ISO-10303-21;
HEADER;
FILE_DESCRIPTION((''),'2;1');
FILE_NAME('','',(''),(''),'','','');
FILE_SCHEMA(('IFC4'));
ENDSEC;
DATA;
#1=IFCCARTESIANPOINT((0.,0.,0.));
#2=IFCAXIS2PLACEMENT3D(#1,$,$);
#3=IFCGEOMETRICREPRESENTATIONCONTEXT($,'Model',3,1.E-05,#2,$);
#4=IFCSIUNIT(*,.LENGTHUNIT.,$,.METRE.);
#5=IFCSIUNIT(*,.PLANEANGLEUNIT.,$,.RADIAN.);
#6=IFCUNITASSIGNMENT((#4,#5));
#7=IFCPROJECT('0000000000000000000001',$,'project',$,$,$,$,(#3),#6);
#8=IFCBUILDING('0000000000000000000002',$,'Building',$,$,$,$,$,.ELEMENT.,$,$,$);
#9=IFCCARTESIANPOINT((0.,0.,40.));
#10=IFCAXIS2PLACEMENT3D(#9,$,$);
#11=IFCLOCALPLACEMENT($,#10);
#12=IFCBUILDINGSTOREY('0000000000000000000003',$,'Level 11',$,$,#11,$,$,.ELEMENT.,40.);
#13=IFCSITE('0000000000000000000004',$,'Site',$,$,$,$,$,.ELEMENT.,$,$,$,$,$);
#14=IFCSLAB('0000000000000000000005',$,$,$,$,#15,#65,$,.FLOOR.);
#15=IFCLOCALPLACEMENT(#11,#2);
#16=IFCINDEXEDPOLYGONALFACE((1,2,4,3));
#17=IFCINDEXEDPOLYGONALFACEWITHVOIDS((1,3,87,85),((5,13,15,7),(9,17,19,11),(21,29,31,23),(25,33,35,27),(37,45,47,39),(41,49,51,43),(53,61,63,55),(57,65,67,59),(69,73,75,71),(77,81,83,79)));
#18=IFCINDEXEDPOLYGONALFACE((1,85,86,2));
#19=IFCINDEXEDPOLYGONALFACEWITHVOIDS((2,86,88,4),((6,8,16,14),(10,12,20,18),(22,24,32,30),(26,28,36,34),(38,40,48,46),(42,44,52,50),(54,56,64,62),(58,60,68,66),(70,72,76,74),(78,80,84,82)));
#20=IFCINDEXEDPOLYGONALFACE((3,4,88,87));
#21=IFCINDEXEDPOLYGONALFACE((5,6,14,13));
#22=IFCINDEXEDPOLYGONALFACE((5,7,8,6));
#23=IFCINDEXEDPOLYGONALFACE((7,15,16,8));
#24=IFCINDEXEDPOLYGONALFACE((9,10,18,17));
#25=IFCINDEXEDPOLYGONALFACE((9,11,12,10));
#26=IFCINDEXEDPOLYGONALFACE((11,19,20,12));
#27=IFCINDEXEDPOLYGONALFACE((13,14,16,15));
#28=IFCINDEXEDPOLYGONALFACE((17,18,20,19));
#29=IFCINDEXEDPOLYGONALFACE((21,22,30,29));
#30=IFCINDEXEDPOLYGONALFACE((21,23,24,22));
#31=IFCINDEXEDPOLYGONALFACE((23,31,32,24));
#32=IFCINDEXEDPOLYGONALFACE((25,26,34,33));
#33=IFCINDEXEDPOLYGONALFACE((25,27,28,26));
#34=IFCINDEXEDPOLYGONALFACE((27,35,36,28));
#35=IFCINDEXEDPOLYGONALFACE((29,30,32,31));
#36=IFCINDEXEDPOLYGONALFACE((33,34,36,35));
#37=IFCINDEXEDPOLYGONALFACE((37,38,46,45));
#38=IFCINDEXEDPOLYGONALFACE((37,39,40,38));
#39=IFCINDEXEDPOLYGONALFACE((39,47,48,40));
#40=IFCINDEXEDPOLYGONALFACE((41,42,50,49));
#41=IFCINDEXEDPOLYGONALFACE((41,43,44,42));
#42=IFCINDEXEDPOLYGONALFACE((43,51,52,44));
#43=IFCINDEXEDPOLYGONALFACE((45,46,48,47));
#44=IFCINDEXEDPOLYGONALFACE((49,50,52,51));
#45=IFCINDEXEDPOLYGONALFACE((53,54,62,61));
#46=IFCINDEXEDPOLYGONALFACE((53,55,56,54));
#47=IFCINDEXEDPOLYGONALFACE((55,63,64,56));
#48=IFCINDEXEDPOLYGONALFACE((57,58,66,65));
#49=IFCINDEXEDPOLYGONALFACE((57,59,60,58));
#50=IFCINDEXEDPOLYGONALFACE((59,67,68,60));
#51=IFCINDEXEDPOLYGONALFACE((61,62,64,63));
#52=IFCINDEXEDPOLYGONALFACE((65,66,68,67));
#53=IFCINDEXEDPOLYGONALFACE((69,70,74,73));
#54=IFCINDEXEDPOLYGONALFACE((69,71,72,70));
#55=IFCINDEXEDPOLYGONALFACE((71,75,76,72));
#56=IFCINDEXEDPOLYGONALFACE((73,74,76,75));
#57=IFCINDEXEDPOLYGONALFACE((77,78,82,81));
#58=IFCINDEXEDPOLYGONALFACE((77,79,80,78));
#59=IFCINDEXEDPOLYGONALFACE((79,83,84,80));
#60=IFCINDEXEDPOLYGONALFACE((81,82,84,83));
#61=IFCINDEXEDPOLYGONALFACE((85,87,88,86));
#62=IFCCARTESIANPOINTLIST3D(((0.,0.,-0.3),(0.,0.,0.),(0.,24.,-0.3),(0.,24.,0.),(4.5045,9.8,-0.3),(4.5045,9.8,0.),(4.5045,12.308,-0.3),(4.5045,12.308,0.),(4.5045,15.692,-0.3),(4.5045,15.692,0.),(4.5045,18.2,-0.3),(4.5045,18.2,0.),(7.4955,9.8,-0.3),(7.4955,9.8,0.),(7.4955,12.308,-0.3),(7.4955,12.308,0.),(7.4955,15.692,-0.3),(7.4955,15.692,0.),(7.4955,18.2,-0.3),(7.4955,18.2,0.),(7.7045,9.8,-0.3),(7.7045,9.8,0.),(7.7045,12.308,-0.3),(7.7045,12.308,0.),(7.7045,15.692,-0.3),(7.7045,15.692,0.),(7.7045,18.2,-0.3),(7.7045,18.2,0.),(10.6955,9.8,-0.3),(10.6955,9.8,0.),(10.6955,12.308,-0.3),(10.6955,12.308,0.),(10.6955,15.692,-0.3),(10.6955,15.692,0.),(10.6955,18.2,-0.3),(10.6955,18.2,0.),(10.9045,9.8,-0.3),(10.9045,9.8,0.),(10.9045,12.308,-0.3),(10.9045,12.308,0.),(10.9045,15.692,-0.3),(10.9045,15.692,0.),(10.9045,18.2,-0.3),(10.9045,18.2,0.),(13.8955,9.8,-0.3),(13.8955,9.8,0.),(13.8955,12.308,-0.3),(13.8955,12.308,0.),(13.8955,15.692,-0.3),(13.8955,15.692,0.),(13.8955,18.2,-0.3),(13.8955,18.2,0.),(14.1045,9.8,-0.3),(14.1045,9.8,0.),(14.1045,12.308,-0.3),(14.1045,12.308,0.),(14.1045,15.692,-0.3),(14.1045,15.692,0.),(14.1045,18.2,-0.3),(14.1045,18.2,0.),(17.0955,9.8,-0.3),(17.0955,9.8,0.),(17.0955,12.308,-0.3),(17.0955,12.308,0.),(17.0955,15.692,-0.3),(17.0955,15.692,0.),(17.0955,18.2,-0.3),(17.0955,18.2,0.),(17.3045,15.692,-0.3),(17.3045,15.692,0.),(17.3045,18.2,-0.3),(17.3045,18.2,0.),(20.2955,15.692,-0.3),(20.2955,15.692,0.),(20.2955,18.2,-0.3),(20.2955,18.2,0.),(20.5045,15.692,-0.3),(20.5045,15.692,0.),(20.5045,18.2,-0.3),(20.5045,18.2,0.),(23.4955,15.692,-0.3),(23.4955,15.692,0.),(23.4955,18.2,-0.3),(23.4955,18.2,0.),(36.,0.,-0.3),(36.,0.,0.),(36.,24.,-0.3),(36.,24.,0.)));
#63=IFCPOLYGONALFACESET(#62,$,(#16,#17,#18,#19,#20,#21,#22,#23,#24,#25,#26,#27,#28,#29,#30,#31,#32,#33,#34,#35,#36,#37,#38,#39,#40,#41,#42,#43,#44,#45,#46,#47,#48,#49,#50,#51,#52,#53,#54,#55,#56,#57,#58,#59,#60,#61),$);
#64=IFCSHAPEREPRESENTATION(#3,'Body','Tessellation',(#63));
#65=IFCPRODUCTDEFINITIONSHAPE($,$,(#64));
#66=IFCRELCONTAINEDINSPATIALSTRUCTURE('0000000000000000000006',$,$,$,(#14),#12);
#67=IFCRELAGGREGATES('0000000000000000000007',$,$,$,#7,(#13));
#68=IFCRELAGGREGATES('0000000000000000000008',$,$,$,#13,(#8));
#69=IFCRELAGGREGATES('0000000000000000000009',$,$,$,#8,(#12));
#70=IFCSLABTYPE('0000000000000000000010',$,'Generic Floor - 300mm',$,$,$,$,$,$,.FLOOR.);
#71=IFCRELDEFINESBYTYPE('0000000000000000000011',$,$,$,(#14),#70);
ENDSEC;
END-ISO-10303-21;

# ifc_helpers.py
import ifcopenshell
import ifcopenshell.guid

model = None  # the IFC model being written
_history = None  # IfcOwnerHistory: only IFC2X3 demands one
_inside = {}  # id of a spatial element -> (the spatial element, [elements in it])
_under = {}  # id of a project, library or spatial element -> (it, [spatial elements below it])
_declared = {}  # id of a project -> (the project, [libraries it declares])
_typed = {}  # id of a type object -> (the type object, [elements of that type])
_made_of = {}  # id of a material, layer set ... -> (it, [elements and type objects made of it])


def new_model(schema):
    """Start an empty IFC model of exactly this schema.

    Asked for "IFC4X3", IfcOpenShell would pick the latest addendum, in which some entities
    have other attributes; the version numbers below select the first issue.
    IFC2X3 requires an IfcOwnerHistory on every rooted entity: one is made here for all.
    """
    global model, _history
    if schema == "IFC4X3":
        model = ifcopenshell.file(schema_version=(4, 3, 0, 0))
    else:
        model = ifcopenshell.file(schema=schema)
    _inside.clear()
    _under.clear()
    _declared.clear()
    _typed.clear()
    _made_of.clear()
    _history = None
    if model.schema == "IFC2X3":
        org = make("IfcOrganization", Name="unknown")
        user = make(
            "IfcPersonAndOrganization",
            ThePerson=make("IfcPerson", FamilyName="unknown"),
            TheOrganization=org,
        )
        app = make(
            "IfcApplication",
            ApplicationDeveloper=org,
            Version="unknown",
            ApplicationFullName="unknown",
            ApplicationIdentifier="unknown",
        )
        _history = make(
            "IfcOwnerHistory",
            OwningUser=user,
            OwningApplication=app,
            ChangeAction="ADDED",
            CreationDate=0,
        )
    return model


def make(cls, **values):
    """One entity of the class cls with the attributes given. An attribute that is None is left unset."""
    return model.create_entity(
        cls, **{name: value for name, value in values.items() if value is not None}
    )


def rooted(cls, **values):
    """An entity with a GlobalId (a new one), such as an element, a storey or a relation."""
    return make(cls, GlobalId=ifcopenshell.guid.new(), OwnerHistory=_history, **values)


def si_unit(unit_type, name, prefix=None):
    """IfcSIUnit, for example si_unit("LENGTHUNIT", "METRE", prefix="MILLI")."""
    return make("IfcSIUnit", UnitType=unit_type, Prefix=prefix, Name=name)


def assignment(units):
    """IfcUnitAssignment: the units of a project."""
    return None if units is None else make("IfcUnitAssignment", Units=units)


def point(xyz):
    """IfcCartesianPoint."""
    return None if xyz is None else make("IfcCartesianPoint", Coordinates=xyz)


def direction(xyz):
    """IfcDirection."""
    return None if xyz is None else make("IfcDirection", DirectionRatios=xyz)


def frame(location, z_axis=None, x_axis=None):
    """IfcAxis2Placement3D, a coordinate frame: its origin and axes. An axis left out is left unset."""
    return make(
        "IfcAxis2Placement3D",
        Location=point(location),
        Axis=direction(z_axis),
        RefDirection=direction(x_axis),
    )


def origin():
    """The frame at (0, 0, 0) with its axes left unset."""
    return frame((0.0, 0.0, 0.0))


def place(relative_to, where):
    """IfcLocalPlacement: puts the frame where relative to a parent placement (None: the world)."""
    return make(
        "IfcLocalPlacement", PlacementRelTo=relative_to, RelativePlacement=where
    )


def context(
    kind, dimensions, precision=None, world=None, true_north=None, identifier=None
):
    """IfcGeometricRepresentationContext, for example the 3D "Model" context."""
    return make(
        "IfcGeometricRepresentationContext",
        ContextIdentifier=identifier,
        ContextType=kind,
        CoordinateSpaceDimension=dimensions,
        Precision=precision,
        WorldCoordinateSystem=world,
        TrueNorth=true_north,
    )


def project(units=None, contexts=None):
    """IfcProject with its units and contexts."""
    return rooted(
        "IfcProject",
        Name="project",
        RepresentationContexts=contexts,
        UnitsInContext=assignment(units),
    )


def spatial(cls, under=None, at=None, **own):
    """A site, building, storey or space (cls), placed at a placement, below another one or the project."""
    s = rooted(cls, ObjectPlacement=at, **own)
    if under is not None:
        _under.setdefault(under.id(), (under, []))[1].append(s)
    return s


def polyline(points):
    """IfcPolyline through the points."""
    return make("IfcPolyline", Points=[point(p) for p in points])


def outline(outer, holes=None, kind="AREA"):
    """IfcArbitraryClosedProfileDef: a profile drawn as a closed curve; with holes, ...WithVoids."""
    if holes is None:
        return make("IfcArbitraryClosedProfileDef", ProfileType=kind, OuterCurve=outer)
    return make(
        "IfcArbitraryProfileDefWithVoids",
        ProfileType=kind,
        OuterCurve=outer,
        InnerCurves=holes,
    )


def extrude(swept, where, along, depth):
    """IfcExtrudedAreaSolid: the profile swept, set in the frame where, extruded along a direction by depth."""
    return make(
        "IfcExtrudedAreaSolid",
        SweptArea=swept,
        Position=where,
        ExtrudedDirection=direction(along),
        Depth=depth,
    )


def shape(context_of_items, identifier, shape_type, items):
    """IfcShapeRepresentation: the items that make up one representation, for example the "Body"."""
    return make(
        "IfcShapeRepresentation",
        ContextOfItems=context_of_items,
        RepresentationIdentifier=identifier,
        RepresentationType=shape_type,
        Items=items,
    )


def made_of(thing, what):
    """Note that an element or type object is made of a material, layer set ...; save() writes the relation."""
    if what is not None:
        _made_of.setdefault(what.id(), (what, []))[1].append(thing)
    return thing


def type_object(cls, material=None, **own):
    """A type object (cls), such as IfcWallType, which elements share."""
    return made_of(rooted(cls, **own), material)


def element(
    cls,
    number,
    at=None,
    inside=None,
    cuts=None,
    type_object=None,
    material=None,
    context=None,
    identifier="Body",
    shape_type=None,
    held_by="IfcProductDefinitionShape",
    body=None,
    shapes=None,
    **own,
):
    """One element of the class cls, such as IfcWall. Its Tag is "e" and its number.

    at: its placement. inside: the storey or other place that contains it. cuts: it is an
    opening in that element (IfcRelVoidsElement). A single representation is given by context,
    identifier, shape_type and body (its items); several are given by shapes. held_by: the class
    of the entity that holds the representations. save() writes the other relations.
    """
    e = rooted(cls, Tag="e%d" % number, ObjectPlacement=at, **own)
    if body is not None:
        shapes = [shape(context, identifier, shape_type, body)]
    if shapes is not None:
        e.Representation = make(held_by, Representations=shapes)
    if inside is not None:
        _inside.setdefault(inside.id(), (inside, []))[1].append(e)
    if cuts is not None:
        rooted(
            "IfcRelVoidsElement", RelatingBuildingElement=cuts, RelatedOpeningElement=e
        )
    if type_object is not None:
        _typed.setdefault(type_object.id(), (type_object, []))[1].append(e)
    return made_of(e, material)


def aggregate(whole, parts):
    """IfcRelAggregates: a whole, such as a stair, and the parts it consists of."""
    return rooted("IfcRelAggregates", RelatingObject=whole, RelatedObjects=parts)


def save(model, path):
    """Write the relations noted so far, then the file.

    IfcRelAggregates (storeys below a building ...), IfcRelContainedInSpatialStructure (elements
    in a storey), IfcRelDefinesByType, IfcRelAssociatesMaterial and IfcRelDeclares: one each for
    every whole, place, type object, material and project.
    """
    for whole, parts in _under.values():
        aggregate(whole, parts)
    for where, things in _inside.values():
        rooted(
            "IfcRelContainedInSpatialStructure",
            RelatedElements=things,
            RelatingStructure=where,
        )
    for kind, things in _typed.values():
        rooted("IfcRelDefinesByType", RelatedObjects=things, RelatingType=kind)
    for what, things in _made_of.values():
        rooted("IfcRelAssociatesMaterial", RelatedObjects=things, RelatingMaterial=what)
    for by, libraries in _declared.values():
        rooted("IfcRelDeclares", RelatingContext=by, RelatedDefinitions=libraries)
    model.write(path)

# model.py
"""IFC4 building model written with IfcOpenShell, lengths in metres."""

from ifc_helpers import new_model, si_unit, frame, origin, place, context, project, spatial, polyline, outline, extrude, type_object, element, save


model = new_model("IFC4")

# Units and contexts
model_context = context("Model", 3, precision=1e-05, world=origin())
ifc_project = project(units=[si_unit("LENGTHUNIT", "METRE"), si_unit("PLANEANGLEUNIT", "RADIAN")], contexts=[model_context])

# Site, building, storey
site = spatial("IfcSite", under=ifc_project, Name="Site", CompositionType="ELEMENT")
building = spatial("IfcBuilding", under=site, Name="Building", CompositionType="ELEMENT")
storey_placement = place(None, frame((0.0, 0.0, 40.0)))
storey = spatial("IfcBuildingStorey", under=building, at=storey_placement, Name="Level 11", CompositionType="ELEMENT", Elevation=40.0)

# Slab, openings
slab_type = type_object("IfcSlabType", Name="Generic Floor - 300mm", PredefinedType="FLOOR")
slab_placement = place(None, frame((0.0, 0.0, 40.0)))
slab = element("IfcSlab", 1, at=slab_placement, inside=storey, type_object=slab_type, PredefinedType="FLOOR", context=model_context, shape_type="SweptSolid", body=[
    extrude(outline(polyline([(0.0, 0.0), (36.0, 0.0), (36.0, 24.0), (0.0, 24.0), (0.0, 0.0)])), origin(), (0.0, 0.0, -1.0), 0.3),
])
opening_1_placement = place(None, frame((0.0, 0.0, 40.001)))
element("IfcOpeningElement", 2, at=opening_1_placement, cuts=slab, PredefinedType="OPENING", context=model_context, shape_type="SweptSolid", body=[
    extrude(outline(polyline([(4.5045, 9.8), (7.4955, 9.8), (7.4955, 12.308), (4.5045, 12.308), (4.5045, 9.8)])), origin(), (0.0, 0.0, -1.0), 0.302),
])
opening_2_placement = place(None, frame((0.0, 0.0, 40.001)))
element("IfcOpeningElement", 3, at=opening_2_placement, cuts=slab, PredefinedType="OPENING", context=model_context, shape_type="SweptSolid", body=[
    extrude(outline(polyline([(7.7045, 9.8), (10.6955, 9.8), (10.6955, 12.308), (7.7045, 12.308), (7.7045, 9.8)])), origin(), (0.0, 0.0, -1.0), 0.302),
])
opening_3_placement = place(None, frame((0.0, 0.0, 40.001)))
element("IfcOpeningElement", 4, at=opening_3_placement, cuts=slab, PredefinedType="OPENING", context=model_context, shape_type="SweptSolid", body=[
    extrude(outline(polyline([(10.9045, 9.8), (13.8955, 9.8), (13.8955, 12.308), (10.9045, 12.308), (10.9045, 9.8)])), origin(), (0.0, 0.0, -1.0), 0.302),
])
opening_4_placement = place(None, frame((0.0, 0.0, 40.001)))
element("IfcOpeningElement", 5, at=opening_4_placement, cuts=slab, PredefinedType="OPENING", context=model_context, shape_type="SweptSolid", body=[
    extrude(outline(polyline([(14.1045, 9.8), (17.0955, 9.8), (17.0955, 12.308), (14.1045, 12.308), (14.1045, 9.8)])), origin(), (0.0, 0.0, -1.0), 0.302),
])
opening_5_placement = place(None, frame((0.0, 0.0, 40.001)))
element("IfcOpeningElement", 6, at=opening_5_placement, cuts=slab, PredefinedType="OPENING", context=model_context, shape_type="SweptSolid", body=[
    extrude(outline(polyline([(7.4955, 18.2), (4.5045, 18.2), (4.5045, 15.692), (7.4955, 15.692), (7.4955, 18.2)])), origin(), (0.0, 0.0, -1.0), 0.302),
])
opening_6_placement = place(None, frame((0.0, 0.0, 40.001)))
element("IfcOpeningElement", 7, at=opening_6_placement, cuts=slab, PredefinedType="OPENING", context=model_context, shape_type="SweptSolid", body=[
    extrude(outline(polyline([(10.6955, 18.2), (7.7045, 18.2), (7.7045, 15.692), (10.6955, 15.692), (10.6955, 18.2)])), origin(), (0.0, 0.0, -1.0), 0.302),
])
opening_7_placement = place(None, frame((0.0, 0.0, 40.001)))
element("IfcOpeningElement", 8, at=opening_7_placement, cuts=slab, PredefinedType="OPENING", context=model_context, shape_type="SweptSolid", body=[
    extrude(outline(polyline([(13.8955, 18.2), (10.9045, 18.2), (10.9045, 15.692), (13.8955, 15.692), (13.8955, 18.2)])), origin(), (0.0, 0.0, -1.0), 0.302),
])
opening_8_placement = place(None, frame((0.0, 0.0, 40.001)))
element("IfcOpeningElement", 9, at=opening_8_placement, cuts=slab, PredefinedType="OPENING", context=model_context, shape_type="SweptSolid", body=[
    extrude(outline(polyline([(17.0955, 18.2), (14.1045, 18.2), (14.1045, 15.692), (17.0955, 15.692), (17.0955, 18.2)])), origin(), (0.0, 0.0, -1.0), 0.302),
])
opening_9_placement = place(None, frame((0.0, 0.0, 40.001)))
element("IfcOpeningElement", 10, at=opening_9_placement, cuts=slab, PredefinedType="OPENING", context=model_context, shape_type="SweptSolid", body=[
    extrude(outline(polyline([(20.2955, 18.2), (17.3045, 18.2), (17.3045, 15.692), (20.2955, 15.692), (20.2955, 18.2)])), origin(), (0.0, 0.0, -1.0), 0.302),
])
opening_10_placement = place(None, frame((0.0, 0.0, 40.001)))
element("IfcOpeningElement", 11, at=opening_10_placement, cuts=slab, PredefinedType="OPENING", context=model_context, shape_type="SweptSolid", body=[
    extrude(outline(polyline([(23.4955, 18.2), (20.5045, 18.2), (20.5045, 15.692), (23.4955, 15.692), (23.4955, 18.2)])), origin(), (0.0, 0.0, -1.0), 0.302),
])

save(model, "model.ifc")
